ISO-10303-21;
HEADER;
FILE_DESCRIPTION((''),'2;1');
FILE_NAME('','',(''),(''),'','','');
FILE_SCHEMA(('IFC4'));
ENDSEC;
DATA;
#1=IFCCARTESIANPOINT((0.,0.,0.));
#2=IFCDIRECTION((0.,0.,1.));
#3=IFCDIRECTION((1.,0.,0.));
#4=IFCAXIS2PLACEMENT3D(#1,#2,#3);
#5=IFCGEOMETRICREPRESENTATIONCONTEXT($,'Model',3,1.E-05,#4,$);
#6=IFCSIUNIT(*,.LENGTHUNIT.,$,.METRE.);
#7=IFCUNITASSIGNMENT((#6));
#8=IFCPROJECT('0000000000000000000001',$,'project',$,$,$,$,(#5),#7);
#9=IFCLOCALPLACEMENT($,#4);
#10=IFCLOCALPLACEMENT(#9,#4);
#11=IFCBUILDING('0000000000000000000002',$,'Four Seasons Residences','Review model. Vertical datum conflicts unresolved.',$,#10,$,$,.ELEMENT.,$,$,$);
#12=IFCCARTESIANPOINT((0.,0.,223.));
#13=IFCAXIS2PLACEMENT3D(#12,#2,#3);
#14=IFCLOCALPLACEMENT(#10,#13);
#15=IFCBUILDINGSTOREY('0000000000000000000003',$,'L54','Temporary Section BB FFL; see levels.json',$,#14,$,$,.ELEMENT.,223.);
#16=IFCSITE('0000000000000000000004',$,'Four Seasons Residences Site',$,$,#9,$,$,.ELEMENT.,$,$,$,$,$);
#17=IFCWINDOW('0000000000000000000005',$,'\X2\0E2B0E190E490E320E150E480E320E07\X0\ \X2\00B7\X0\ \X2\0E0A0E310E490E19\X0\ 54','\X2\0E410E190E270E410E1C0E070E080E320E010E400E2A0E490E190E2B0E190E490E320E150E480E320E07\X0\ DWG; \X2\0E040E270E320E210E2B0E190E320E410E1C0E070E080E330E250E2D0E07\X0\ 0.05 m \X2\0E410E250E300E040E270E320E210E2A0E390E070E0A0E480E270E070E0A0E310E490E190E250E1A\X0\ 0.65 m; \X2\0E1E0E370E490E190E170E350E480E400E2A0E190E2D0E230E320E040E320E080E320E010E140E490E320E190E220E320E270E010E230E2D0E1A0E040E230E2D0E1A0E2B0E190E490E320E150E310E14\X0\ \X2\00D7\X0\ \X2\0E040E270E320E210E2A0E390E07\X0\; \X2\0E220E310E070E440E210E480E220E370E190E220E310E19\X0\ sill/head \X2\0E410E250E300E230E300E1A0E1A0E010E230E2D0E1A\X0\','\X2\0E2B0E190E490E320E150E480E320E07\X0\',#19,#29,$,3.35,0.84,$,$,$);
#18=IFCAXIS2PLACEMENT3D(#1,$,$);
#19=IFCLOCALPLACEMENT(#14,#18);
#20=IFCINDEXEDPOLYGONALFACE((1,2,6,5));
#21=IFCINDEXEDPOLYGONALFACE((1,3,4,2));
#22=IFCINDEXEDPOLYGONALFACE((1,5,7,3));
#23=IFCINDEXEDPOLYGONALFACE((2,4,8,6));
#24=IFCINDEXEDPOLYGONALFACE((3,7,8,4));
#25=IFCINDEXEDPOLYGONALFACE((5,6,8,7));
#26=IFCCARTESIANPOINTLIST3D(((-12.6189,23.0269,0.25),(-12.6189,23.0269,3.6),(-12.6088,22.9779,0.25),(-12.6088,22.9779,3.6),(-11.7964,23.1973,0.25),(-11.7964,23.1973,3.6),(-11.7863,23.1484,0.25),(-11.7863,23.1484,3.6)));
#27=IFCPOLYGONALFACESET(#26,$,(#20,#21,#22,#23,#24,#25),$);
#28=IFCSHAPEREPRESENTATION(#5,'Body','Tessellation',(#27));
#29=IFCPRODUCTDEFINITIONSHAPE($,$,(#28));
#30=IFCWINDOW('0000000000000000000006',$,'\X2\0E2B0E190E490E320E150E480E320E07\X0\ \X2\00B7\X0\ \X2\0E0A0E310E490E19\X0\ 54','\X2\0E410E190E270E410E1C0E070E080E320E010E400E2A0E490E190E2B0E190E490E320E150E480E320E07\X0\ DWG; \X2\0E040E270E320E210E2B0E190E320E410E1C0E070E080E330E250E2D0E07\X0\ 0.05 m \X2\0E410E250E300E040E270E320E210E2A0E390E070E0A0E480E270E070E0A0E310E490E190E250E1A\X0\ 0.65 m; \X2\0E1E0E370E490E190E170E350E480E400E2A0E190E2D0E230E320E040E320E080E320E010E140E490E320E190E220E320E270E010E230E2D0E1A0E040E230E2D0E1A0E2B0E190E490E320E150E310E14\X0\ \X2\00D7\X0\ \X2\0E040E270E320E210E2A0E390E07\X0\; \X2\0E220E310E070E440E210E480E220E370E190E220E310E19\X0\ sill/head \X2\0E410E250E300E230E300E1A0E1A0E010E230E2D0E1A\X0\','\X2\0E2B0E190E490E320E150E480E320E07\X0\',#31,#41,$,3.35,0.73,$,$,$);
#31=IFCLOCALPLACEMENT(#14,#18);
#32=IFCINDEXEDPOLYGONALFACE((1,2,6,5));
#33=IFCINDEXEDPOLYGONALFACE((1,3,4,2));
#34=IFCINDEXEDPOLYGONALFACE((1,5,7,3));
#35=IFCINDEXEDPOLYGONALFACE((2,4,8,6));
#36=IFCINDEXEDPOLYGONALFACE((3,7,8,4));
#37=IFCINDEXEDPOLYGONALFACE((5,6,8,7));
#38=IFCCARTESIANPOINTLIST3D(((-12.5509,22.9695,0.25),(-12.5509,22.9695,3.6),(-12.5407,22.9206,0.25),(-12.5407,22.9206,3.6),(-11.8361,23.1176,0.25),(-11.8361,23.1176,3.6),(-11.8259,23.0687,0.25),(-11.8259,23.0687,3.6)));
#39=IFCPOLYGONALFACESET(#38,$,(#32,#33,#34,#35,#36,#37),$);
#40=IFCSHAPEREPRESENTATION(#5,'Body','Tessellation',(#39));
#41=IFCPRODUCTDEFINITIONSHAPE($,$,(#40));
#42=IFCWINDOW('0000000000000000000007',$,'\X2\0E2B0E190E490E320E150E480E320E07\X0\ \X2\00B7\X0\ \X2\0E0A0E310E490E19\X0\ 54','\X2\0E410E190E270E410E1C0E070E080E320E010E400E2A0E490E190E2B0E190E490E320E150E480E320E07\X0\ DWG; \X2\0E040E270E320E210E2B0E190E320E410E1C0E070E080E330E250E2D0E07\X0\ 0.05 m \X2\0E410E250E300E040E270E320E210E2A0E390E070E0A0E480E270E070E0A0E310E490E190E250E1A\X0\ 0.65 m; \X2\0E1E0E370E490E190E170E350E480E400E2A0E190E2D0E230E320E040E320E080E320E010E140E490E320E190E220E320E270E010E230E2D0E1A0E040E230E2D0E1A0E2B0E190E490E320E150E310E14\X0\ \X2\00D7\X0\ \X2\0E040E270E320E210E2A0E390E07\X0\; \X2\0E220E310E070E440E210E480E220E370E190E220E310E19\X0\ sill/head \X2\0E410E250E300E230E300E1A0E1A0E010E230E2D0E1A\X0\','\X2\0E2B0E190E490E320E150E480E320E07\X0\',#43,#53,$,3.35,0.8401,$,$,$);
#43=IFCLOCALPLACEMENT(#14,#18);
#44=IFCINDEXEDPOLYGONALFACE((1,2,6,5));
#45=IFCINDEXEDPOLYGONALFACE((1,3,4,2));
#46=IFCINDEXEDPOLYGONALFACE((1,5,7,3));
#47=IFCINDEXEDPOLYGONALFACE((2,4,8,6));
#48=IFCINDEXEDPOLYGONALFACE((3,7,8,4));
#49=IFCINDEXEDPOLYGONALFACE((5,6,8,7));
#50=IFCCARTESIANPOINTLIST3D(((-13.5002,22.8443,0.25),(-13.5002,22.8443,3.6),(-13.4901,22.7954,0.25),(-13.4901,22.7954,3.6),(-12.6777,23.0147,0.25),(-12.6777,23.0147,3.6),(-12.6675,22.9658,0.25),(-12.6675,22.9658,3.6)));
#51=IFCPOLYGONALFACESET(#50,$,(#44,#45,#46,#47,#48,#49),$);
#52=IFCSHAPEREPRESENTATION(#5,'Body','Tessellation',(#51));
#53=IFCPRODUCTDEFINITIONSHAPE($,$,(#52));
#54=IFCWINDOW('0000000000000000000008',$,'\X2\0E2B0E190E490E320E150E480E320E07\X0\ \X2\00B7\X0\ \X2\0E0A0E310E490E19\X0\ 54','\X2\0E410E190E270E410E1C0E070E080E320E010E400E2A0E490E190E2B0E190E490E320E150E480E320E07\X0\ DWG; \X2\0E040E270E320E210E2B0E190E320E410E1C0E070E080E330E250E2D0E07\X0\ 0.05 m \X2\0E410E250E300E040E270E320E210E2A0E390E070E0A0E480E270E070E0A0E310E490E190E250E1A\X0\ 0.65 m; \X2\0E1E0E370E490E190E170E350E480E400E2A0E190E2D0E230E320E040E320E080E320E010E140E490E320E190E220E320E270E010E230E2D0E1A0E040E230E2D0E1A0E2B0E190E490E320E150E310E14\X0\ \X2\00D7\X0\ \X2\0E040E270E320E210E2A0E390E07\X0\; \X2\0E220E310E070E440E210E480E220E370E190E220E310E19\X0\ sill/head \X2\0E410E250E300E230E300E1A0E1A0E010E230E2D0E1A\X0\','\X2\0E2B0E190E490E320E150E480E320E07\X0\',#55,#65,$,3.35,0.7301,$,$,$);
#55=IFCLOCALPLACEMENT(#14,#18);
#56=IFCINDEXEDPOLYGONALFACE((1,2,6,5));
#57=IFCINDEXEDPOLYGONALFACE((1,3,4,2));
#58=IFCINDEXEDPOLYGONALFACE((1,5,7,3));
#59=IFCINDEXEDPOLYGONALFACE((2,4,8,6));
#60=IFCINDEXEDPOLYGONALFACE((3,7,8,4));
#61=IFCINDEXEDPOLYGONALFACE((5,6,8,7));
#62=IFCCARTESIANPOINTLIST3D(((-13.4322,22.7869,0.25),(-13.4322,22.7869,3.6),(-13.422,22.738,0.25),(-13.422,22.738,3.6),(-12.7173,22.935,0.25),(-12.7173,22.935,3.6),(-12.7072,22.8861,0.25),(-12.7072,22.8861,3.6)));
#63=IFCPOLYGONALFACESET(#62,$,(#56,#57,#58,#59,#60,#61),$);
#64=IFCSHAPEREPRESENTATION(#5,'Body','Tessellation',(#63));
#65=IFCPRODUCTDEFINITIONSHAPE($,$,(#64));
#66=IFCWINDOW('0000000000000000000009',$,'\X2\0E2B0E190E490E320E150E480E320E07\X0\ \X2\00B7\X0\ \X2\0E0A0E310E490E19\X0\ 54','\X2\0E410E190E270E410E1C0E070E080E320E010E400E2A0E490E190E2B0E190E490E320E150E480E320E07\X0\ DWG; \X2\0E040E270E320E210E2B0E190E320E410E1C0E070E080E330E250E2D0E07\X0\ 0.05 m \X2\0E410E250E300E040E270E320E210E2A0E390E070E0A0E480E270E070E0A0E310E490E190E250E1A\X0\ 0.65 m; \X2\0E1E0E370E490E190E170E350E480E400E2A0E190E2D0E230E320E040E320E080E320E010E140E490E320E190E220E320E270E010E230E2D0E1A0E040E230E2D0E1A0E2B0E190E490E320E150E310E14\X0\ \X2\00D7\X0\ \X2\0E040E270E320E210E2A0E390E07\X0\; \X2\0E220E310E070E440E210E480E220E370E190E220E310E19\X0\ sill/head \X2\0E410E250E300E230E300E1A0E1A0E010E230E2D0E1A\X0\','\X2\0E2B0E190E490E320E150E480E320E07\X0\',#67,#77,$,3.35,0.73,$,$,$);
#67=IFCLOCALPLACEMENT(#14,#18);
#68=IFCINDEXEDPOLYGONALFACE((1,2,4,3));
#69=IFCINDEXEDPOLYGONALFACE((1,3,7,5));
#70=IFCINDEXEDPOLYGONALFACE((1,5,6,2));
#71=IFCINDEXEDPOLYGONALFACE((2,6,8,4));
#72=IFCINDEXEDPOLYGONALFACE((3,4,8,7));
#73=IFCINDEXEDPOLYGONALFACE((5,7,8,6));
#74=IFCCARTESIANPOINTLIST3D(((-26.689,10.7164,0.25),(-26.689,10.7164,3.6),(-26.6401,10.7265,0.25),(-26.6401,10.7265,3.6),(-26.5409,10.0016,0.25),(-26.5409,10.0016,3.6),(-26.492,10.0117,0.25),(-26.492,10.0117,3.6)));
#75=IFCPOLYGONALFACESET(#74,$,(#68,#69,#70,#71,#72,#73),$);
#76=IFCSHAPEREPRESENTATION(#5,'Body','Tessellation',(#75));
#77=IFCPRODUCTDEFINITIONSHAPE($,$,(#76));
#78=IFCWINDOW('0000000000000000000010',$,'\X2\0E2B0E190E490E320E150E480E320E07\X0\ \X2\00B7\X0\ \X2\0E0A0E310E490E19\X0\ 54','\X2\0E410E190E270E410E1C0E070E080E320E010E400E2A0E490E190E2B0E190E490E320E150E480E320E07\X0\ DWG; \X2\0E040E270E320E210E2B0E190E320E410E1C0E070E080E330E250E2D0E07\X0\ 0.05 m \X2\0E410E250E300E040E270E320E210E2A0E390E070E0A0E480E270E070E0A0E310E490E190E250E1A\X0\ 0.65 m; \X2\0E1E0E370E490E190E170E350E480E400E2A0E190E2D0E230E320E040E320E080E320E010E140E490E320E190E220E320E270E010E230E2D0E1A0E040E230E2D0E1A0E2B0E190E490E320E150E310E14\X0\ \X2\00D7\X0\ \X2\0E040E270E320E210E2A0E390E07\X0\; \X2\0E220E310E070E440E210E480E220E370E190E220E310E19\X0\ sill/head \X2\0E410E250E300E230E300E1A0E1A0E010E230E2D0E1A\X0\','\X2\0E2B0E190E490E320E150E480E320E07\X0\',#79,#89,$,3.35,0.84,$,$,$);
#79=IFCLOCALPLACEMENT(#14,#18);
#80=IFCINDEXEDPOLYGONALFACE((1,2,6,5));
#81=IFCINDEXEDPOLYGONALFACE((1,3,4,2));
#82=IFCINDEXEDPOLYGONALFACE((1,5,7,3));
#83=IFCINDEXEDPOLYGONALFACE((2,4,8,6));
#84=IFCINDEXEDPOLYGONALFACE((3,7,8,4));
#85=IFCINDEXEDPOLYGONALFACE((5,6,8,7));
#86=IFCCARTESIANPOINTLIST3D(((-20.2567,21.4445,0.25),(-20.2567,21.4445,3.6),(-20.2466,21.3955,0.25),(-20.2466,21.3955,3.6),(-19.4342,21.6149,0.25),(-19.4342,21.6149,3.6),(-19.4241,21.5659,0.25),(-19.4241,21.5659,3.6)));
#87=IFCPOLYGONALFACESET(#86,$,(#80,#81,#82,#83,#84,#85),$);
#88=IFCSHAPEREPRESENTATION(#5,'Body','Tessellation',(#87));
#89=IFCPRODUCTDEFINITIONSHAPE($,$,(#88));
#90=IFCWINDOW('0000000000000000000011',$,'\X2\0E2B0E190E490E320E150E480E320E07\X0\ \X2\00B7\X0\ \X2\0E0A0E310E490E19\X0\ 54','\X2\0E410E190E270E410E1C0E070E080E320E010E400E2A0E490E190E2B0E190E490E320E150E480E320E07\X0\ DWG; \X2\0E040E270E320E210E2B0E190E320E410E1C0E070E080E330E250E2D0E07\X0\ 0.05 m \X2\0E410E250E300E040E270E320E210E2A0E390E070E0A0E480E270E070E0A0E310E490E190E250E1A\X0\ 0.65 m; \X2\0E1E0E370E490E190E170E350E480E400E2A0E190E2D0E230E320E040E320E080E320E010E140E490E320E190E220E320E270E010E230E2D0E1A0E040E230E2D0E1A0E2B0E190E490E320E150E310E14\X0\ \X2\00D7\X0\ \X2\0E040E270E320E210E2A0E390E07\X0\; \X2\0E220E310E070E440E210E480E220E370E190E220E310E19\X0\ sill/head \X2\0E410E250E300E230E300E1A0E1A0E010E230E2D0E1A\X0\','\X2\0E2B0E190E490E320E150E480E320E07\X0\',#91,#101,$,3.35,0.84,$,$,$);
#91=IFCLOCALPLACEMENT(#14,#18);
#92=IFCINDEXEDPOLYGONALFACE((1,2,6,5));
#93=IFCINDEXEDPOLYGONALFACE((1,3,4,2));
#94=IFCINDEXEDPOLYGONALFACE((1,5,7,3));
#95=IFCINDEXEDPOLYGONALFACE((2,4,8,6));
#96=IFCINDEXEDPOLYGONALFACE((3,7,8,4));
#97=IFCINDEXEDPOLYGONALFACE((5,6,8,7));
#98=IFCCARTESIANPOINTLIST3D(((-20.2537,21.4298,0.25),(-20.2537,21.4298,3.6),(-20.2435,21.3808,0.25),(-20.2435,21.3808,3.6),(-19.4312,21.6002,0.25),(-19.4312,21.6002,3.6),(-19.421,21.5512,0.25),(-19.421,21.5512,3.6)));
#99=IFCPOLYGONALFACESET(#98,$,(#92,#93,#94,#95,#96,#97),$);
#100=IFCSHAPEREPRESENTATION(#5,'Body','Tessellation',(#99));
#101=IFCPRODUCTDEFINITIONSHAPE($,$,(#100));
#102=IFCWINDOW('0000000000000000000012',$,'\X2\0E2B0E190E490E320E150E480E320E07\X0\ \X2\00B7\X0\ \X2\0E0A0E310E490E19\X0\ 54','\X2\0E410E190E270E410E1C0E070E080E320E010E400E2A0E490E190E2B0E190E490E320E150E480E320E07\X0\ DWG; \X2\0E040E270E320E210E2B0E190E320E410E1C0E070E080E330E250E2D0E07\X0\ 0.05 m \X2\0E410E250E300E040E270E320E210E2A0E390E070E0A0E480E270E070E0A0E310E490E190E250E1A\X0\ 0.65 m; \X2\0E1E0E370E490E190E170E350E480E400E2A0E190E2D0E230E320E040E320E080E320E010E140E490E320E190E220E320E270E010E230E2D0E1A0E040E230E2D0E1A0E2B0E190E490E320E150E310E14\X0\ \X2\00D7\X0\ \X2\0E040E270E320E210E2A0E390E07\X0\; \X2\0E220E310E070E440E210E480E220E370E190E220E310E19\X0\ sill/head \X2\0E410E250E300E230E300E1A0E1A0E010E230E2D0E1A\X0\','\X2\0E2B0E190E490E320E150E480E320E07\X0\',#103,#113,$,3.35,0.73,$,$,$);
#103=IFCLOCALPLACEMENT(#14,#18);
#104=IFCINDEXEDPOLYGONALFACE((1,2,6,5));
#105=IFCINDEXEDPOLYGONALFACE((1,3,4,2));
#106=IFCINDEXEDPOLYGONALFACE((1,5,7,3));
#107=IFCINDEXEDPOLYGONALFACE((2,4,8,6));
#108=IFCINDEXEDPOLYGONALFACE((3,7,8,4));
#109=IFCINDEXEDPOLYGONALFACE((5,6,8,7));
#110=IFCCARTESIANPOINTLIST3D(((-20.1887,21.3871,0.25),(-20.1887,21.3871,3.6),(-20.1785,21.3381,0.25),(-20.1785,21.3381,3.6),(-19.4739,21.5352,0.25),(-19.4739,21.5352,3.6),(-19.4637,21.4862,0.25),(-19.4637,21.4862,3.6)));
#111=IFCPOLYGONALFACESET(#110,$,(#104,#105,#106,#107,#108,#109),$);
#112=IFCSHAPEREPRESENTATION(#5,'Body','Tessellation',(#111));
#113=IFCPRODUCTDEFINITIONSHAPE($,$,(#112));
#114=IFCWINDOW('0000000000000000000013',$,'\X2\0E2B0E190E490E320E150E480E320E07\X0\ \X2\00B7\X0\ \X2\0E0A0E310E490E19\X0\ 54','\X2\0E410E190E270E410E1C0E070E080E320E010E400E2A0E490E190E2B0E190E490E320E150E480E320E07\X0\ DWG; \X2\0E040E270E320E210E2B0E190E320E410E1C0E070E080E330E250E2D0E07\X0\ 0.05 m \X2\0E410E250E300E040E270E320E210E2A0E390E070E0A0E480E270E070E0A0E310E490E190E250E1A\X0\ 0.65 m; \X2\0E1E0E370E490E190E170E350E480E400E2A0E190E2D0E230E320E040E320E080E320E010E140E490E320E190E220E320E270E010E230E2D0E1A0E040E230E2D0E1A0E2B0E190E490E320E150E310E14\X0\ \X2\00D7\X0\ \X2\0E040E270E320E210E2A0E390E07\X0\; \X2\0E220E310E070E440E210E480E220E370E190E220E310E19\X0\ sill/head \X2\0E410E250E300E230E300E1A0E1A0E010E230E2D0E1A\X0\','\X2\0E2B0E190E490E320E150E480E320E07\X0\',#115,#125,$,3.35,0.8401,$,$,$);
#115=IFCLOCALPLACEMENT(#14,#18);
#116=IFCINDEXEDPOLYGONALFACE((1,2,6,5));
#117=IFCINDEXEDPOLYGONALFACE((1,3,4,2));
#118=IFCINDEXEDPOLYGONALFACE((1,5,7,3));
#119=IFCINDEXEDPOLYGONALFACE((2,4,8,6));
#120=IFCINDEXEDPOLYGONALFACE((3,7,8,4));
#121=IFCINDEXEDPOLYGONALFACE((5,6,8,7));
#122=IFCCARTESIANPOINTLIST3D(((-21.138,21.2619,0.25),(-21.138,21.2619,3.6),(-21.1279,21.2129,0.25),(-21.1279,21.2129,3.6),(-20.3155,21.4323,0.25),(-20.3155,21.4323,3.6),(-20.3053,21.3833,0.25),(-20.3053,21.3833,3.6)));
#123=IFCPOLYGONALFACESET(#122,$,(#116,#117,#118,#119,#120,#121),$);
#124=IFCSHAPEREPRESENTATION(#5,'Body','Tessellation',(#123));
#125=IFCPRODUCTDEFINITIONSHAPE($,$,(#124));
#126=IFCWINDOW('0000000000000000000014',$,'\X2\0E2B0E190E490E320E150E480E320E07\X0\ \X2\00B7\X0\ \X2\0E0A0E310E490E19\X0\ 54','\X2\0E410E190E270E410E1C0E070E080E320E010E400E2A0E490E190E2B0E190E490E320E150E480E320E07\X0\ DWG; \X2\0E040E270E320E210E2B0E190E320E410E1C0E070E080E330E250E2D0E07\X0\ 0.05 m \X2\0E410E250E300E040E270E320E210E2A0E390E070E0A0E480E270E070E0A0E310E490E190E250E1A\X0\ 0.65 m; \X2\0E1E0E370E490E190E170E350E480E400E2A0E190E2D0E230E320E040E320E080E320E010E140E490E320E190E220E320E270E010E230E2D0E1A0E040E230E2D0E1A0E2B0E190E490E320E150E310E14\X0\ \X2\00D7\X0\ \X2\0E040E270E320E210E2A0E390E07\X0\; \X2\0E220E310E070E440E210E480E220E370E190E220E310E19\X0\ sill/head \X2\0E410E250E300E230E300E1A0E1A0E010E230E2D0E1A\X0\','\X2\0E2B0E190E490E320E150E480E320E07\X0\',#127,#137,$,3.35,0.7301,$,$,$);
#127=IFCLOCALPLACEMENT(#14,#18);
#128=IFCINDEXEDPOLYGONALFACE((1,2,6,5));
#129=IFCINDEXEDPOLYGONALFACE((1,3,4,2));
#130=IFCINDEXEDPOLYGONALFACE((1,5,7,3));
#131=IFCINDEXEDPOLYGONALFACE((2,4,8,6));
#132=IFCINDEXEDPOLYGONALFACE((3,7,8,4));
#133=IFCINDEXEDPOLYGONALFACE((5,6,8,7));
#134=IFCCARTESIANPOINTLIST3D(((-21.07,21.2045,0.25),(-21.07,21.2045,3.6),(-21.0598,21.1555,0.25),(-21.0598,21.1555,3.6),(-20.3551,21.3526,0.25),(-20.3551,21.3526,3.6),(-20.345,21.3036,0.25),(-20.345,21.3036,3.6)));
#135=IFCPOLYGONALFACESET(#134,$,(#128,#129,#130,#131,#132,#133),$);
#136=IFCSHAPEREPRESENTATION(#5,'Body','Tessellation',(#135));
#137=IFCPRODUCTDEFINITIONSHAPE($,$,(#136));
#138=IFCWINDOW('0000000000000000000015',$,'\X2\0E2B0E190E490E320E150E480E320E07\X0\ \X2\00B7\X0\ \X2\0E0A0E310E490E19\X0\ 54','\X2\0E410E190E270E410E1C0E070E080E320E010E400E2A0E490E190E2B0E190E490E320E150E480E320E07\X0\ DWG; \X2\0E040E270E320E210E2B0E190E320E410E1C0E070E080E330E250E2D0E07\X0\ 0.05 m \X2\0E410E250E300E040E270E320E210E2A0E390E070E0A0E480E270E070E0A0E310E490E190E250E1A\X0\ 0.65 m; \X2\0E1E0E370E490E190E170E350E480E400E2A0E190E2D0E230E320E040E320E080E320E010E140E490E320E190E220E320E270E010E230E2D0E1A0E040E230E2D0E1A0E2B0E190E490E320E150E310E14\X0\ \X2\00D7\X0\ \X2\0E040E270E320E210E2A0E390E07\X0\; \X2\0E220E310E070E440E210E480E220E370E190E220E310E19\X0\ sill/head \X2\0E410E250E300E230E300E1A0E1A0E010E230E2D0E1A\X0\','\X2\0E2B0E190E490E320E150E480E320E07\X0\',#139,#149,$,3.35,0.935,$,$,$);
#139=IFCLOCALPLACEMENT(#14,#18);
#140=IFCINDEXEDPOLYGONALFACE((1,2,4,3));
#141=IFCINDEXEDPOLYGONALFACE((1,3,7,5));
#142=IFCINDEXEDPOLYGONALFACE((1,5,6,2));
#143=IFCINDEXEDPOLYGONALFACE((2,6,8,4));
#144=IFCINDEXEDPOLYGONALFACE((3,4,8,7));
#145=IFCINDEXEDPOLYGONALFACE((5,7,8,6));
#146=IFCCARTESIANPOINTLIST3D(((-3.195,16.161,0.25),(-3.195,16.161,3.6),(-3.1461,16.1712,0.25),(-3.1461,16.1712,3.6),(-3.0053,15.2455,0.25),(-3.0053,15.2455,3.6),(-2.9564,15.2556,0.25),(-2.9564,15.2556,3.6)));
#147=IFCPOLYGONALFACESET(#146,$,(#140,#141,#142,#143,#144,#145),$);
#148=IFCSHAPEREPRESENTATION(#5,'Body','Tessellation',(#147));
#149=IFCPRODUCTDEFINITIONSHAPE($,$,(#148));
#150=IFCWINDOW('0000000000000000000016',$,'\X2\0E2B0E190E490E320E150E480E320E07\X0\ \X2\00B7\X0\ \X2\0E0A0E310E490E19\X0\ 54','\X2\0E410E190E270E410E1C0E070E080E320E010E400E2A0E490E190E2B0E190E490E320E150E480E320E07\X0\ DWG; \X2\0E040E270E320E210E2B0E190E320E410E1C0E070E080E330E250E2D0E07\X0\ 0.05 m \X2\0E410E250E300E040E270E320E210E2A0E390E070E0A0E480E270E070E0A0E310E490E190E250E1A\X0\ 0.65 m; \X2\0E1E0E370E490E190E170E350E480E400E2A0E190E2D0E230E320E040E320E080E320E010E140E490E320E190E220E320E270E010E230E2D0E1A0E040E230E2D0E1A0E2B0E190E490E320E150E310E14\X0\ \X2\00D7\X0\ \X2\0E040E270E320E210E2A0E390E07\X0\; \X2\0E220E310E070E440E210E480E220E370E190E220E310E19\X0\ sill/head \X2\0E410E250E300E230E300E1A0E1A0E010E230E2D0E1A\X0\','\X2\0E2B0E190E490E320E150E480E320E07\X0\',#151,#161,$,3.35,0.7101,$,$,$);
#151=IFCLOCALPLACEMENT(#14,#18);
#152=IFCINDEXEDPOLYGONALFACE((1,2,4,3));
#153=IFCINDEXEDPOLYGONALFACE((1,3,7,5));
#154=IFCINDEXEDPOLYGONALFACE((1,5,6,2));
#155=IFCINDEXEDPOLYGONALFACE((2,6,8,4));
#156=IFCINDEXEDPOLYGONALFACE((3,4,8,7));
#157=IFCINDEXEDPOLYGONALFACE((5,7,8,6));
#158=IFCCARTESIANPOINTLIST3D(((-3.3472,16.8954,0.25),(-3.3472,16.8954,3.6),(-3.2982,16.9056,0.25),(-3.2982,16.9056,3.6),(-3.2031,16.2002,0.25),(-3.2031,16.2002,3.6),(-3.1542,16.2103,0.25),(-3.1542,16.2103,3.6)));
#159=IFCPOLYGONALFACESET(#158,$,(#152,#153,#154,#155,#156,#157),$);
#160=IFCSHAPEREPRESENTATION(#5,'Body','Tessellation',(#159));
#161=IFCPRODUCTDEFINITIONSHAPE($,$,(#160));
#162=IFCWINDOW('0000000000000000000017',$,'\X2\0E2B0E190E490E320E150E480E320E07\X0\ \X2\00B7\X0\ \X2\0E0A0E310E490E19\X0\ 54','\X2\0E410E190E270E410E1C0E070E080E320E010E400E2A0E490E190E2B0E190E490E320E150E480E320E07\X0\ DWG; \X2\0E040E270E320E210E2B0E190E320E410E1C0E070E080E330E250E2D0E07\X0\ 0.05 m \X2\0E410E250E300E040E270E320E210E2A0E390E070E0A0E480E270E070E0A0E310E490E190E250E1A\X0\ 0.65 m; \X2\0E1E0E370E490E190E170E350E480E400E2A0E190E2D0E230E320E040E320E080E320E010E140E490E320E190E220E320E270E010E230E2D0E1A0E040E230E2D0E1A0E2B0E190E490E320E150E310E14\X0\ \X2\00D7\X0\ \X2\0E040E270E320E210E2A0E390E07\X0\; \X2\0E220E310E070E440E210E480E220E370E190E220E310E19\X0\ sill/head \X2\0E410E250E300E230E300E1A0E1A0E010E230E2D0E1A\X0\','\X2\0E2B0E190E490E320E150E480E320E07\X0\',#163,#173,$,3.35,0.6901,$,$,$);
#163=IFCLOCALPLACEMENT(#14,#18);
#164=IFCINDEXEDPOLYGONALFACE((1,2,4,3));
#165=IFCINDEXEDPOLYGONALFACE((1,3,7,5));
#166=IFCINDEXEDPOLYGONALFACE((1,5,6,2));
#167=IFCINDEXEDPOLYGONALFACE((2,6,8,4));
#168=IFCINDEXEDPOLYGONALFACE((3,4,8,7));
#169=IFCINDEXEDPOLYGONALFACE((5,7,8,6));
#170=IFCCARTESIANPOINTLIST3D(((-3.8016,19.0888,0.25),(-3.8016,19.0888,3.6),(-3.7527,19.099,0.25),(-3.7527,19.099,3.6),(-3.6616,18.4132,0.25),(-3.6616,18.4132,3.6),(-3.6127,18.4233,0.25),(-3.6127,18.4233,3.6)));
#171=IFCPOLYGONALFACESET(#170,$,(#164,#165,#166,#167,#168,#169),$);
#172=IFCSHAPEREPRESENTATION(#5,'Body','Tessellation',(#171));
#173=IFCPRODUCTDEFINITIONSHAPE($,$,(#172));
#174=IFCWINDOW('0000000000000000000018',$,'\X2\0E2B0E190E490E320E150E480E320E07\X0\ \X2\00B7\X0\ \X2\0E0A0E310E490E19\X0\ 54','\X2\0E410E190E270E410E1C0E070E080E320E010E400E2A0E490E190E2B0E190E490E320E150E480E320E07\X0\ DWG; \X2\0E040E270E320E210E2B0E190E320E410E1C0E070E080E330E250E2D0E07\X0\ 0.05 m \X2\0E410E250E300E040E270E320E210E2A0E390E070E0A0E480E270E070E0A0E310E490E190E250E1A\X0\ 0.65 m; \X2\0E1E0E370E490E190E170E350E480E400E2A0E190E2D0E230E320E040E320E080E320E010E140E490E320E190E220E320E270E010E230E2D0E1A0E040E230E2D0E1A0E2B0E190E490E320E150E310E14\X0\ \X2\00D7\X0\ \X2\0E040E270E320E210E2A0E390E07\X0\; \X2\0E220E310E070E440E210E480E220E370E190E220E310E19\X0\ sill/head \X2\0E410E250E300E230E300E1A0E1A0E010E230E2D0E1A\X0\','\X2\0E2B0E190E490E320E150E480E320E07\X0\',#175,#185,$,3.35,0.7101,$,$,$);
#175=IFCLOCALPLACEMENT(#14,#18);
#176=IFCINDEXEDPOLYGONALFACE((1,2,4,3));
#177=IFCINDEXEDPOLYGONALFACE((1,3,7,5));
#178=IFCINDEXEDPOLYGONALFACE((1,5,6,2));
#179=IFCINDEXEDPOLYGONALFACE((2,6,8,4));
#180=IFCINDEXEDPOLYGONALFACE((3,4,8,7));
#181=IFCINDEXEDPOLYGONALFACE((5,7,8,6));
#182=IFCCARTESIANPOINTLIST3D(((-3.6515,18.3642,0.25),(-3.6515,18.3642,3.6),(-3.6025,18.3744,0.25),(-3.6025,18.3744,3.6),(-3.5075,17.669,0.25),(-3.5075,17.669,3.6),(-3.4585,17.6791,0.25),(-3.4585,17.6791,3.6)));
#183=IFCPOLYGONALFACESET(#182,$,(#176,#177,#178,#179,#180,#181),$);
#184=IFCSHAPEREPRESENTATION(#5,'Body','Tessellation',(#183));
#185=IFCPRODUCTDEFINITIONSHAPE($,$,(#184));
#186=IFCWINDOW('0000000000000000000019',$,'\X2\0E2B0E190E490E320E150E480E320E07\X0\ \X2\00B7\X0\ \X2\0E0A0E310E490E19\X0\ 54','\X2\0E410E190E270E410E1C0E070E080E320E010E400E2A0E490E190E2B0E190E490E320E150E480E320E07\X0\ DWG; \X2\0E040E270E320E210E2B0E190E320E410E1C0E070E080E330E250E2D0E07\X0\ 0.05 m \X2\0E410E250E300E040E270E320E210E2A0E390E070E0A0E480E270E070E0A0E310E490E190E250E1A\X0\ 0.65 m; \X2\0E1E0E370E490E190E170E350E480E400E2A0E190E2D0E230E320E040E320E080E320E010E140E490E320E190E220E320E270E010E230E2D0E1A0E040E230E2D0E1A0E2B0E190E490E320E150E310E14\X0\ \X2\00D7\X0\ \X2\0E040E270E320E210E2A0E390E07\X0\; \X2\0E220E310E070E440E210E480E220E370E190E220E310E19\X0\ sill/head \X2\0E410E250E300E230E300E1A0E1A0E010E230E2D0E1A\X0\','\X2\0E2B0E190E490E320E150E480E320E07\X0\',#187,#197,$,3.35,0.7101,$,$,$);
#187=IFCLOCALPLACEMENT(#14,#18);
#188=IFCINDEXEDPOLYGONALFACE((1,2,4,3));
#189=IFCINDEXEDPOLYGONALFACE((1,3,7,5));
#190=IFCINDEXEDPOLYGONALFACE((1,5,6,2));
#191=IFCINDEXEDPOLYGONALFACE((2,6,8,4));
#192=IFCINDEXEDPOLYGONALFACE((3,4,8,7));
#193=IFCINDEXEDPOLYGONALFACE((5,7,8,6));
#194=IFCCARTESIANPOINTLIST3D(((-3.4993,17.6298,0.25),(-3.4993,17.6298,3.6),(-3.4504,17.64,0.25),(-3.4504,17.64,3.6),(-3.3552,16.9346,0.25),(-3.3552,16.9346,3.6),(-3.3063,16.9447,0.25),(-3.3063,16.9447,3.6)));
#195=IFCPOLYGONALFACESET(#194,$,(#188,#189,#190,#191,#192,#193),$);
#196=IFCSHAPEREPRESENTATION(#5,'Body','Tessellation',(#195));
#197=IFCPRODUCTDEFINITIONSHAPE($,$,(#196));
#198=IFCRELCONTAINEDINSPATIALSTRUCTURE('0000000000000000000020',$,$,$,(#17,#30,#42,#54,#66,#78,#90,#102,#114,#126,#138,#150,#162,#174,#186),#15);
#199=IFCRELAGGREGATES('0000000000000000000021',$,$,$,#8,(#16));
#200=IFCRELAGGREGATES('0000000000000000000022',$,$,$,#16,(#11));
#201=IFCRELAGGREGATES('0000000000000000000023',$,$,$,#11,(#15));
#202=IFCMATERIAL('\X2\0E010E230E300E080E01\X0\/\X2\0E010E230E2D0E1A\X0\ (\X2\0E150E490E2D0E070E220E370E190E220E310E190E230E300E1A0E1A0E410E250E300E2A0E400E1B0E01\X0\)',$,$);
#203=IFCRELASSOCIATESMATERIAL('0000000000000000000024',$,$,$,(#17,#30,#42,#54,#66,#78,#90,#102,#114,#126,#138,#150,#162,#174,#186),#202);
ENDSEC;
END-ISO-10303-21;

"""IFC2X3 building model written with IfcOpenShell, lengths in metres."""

from ifc_helpers import new_model, si_unit, frame, origin_with_axes, place, context, project, spatial, polyline, outline, extrude, material, element, save


model = new_model("IFC2X3")

# Units and contexts
model_context = context("Model", 3, precision=1e-05, world=origin_with_axes())
ifc_project = project(units=[si_unit("LENGTHUNIT", "METRE")], contexts=[model_context])

# Site, building, storey
site_placement = place(None, origin_with_axes())
site = spatial("IfcSite", under=ifc_project, at=site_placement, Name="Four Seasons Residences Site", CompositionType="ELEMENT")
building_placement = place(site_placement, origin_with_axes())
building = spatial("IfcBuilding", under=site, at=building_placement, Name="Four Seasons Residences", Description="Review model. Vertical datum conflicts unresolved.", CompositionType="ELEMENT")
storey_placement = place(building_placement, frame((0.0, 0.0, 223.0), z_axis=(0.0, 0.0, 1.0), x_axis=(1.0, 0.0, 0.0)))
storey = spatial("IfcBuildingStorey", under=building, at=storey_placement, Name="L54", Description="Temporary Section BB FFL; see levels.json", CompositionType="ELEMENT", Elevation=223.0)

# Windows
ifc_material = material(Name="กระจก/กรอบ (ต้องยืนยันระบบและสเปก)")
window_1_placement = place(storey_placement, origin_with_axes())
element("IfcWindow", 1, at=window_1_placement, inside=storey, material=ifc_material, Name="หน้าต่าง · ชั้น 54", Description="แนวแผงจากเส้นหน้าต่าง DWG; ความหนาแผงจำลอง 0.05 m และความสูงช่วงชั้นลบ 0.65 m; พื้นที่เสนอราคาจากด้านยาวกรอบครอบหน้าตัด × ความสูง; ยังไม่ยืนยัน sill/head และระบบกรอบ", ObjectType="หน้าต่าง", OverallHeight=3.35, OverallWidth=0.84, context=model_context, shape_type="SweptSolid", body=[
    extrude(outline(polyline([(-12.6088, 22.9779), (-12.6189, 23.0269), (-11.7964, 23.1973), (-11.7863, 23.1484), (-12.6088, 22.9779)])), frame((0.0, 0.0, 0.25), z_axis=(0.0, 0.0, 1.0), x_axis=(1.0, 0.0, 0.0)), (0.0, 0.0, 1.0), 3.35),
])
window_2_placement = place(storey_placement, origin_with_axes())
element("IfcWindow", 2, at=window_2_placement, inside=storey, material=ifc_material, Name="หน้าต่าง · ชั้น 54", Description="แนวแผงจากเส้นหน้าต่าง DWG; ความหนาแผงจำลอง 0.05 m และความสูงช่วงชั้นลบ 0.65 m; พื้นที่เสนอราคาจากด้านยาวกรอบครอบหน้าตัด × ความสูง; ยังไม่ยืนยัน sill/head และระบบกรอบ", ObjectType="หน้าต่าง", OverallHeight=3.35, OverallWidth=0.73, context=model_context, shape_type="SweptSolid", body=[
    extrude(outline(polyline([(-12.5407, 22.9206), (-12.5509, 22.9695), (-11.8361, 23.1176), (-11.8259, 23.0687), (-12.5407, 22.9206)])), frame((0.0, 0.0, 0.25), z_axis=(0.0, 0.0, 1.0), x_axis=(1.0, 0.0, 0.0)), (0.0, 0.0, 1.0), 3.35),
])
window_3_placement = place(storey_placement, origin_with_axes())
element("IfcWindow", 3, at=window_3_placement, inside=storey, material=ifc_material, Name="หน้าต่าง · ชั้น 54", Description="แนวแผงจากเส้นหน้าต่าง DWG; ความหนาแผงจำลอง 0.05 m และความสูงช่วงชั้นลบ 0.65 m; พื้นที่เสนอราคาจากด้านยาวกรอบครอบหน้าตัด × ความสูง; ยังไม่ยืนยัน sill/head และระบบกรอบ", ObjectType="หน้าต่าง", OverallHeight=3.35, OverallWidth=0.8401, context=model_context, shape_type="SweptSolid", body=[
    extrude(outline(polyline([(-13.4901, 22.7954), (-13.5002, 22.8443), (-12.6777, 23.0147), (-12.6675, 22.9658), (-13.4901, 22.7954)])), frame((0.0, 0.0, 0.25), z_axis=(0.0, 0.0, 1.0), x_axis=(1.0, 0.0, 0.0)), (0.0, 0.0, 1.0), 3.35),
])
window_4_placement = place(storey_placement, origin_with_axes())
element("IfcWindow", 4, at=window_4_placement, inside=storey, material=ifc_material, Name="หน้าต่าง · ชั้น 54", Description="แนวแผงจากเส้นหน้าต่าง DWG; ความหนาแผงจำลอง 0.05 m และความสูงช่วงชั้นลบ 0.65 m; พื้นที่เสนอราคาจากด้านยาวกรอบครอบหน้าตัด × ความสูง; ยังไม่ยืนยัน sill/head และระบบกรอบ", ObjectType="หน้าต่าง", OverallHeight=3.35, OverallWidth=0.7301, context=model_context, shape_type="SweptSolid", body=[
    extrude(outline(polyline([(-13.422, 22.738), (-13.4322, 22.7869), (-12.7173, 22.935), (-12.7072, 22.8861), (-13.422, 22.738)])), frame((0.0, 0.0, 0.25), z_axis=(0.0, 0.0, 1.0), x_axis=(1.0, 0.0, 0.0)), (0.0, 0.0, 1.0), 3.35),
])
window_5_placement = place(storey_placement, origin_with_axes())
element("IfcWindow", 5, at=window_5_placement, inside=storey, material=ifc_material, Name="หน้าต่าง · ชั้น 54", Description="แนวแผงจากเส้นหน้าต่าง DWG; ความหนาแผงจำลอง 0.05 m และความสูงช่วงชั้นลบ 0.65 m; พื้นที่เสนอราคาจากด้านยาวกรอบครอบหน้าตัด × ความสูง; ยังไม่ยืนยัน sill/head และระบบกรอบ", ObjectType="หน้าต่าง", OverallHeight=3.35, OverallWidth=0.73, context=model_context, shape_type="SweptSolid", body=[
    extrude(outline(polyline([(-26.689, 10.7164), (-26.6401, 10.7265), (-26.492, 10.0117), (-26.5409, 10.0016), (-26.689, 10.7164)])), frame((0.0, 0.0, 0.25), z_axis=(0.0, 0.0, 1.0), x_axis=(1.0, 0.0, 0.0)), (0.0, 0.0, 1.0), 3.35),
])
window_6_placement = place(storey_placement, origin_with_axes())
element("IfcWindow", 6, at=window_6_placement, inside=storey, material=ifc_material, Name="หน้าต่าง · ชั้น 54", Description="แนวแผงจากเส้นหน้าต่าง DWG; ความหนาแผงจำลอง 0.05 m และความสูงช่วงชั้นลบ 0.65 m; พื้นที่เสนอราคาจากด้านยาวกรอบครอบหน้าตัด × ความสูง; ยังไม่ยืนยัน sill/head และระบบกรอบ", ObjectType="หน้าต่าง", OverallHeight=3.35, OverallWidth=0.84, context=model_context, shape_type="SweptSolid", body=[
    extrude(outline(polyline([(-20.2466, 21.3955), (-20.2567, 21.4445), (-19.4342, 21.6149), (-19.4241, 21.5659), (-20.2466, 21.3955)])), frame((0.0, 0.0, 0.25), z_axis=(0.0, 0.0, 1.0), x_axis=(1.0, 0.0, 0.0)), (0.0, 0.0, 1.0), 3.35),
])
window_7_placement = place(storey_placement, origin_with_axes())
element("IfcWindow", 7, at=window_7_placement, inside=storey, material=ifc_material, Name="หน้าต่าง · ชั้น 54", Description="แนวแผงจากเส้นหน้าต่าง DWG; ความหนาแผงจำลอง 0.05 m และความสูงช่วงชั้นลบ 0.65 m; พื้นที่เสนอราคาจากด้านยาวกรอบครอบหน้าตัด × ความสูง; ยังไม่ยืนยัน sill/head และระบบกรอบ", ObjectType="หน้าต่าง", OverallHeight=3.35, OverallWidth=0.84, context=model_context, shape_type="SweptSolid", body=[
    extrude(outline(polyline([(-20.2435, 21.3808), (-20.2537, 21.4298), (-19.4312, 21.6002), (-19.421, 21.5512), (-20.2435, 21.3808)])), frame((0.0, 0.0, 0.25), z_axis=(0.0, 0.0, 1.0), x_axis=(1.0, 0.0, 0.0)), (0.0, 0.0, 1.0), 3.35),
])
window_8_placement = place(storey_placement, origin_with_axes())
element("IfcWindow", 8, at=window_8_placement, inside=storey, material=ifc_material, Name="หน้าต่าง · ชั้น 54", Description="แนวแผงจากเส้นหน้าต่าง DWG; ความหนาแผงจำลอง 0.05 m และความสูงช่วงชั้นลบ 0.65 m; พื้นที่เสนอราคาจากด้านยาวกรอบครอบหน้าตัด × ความสูง; ยังไม่ยืนยัน sill/head และระบบกรอบ", ObjectType="หน้าต่าง", OverallHeight=3.35, OverallWidth=0.73, context=model_context, shape_type="SweptSolid", body=[
    extrude(outline(polyline([(-20.1785, 21.3381), (-20.1887, 21.3871), (-19.4739, 21.5352), (-19.4637, 21.4862), (-20.1785, 21.3381)])), frame((0.0, 0.0, 0.25), z_axis=(0.0, 0.0, 1.0), x_axis=(1.0, 0.0, 0.0)), (0.0, 0.0, 1.0), 3.35),
])
window_9_placement = place(storey_placement, origin_with_axes())
element("IfcWindow", 9, at=window_9_placement, inside=storey, material=ifc_material, Name="หน้าต่าง · ชั้น 54", Description="แนวแผงจากเส้นหน้าต่าง DWG; ความหนาแผงจำลอง 0.05 m และความสูงช่วงชั้นลบ 0.65 m; พื้นที่เสนอราคาจากด้านยาวกรอบครอบหน้าตัด × ความสูง; ยังไม่ยืนยัน sill/head และระบบกรอบ", ObjectType="หน้าต่าง", OverallHeight=3.35, OverallWidth=0.8401, context=model_context, shape_type="SweptSolid", body=[
    extrude(outline(polyline([(-21.1279, 21.2129), (-21.138, 21.2619), (-20.3155, 21.4323), (-20.3053, 21.3833), (-21.1279, 21.2129)])), frame((0.0, 0.0, 0.25), z_axis=(0.0, 0.0, 1.0), x_axis=(1.0, 0.0, 0.0)), (0.0, 0.0, 1.0), 3.35),
])
window_10_placement = place(storey_placement, origin_with_axes())
element("IfcWindow", 10, at=window_10_placement, inside=storey, material=ifc_material, Name="หน้าต่าง · ชั้น 54", Description="แนวแผงจากเส้นหน้าต่าง DWG; ความหนาแผงจำลอง 0.05 m และความสูงช่วงชั้นลบ 0.65 m; พื้นที่เสนอราคาจากด้านยาวกรอบครอบหน้าตัด × ความสูง; ยังไม่ยืนยัน sill/head และระบบกรอบ", ObjectType="หน้าต่าง", OverallHeight=3.35, OverallWidth=0.7301, context=model_context, shape_type="SweptSolid", body=[
    extrude(outline(polyline([(-21.0598, 21.1555), (-21.07, 21.2045), (-20.3551, 21.3526), (-20.345, 21.3036), (-21.0598, 21.1555)])), frame((0.0, 0.0, 0.25), z_axis=(0.0, 0.0, 1.0), x_axis=(1.0, 0.0, 0.0)), (0.0, 0.0, 1.0), 3.35),
])
window_11_placement = place(storey_placement, origin_with_axes())
element("IfcWindow", 11, at=window_11_placement, inside=storey, material=ifc_material, Name="หน้าต่าง · ชั้น 54", Description="แนวแผงจากเส้นหน้าต่าง DWG; ความหนาแผงจำลอง 0.05 m และความสูงช่วงชั้นลบ 0.65 m; พื้นที่เสนอราคาจากด้านยาวกรอบครอบหน้าตัด × ความสูง; ยังไม่ยืนยัน sill/head และระบบกรอบ", ObjectType="หน้าต่าง", OverallHeight=3.35, OverallWidth=0.935, context=model_context, shape_type="SweptSolid", body=[
    extrude(outline(polyline([(-3.195, 16.161), (-3.1461, 16.1712), (-2.9564, 15.2556), (-3.0053, 15.2455), (-3.195, 16.161)])), frame((0.0, 0.0, 0.25), z_axis=(0.0, 0.0, 1.0), x_axis=(1.0, 0.0, 0.0)), (0.0, 0.0, 1.0), 3.35),
])
window_12_placement = place(storey_placement, origin_with_axes())
element("IfcWindow", 12, at=window_12_placement, inside=storey, material=ifc_material, Name="หน้าต่าง · ชั้น 54", Description="แนวแผงจากเส้นหน้าต่าง DWG; ความหนาแผงจำลอง 0.05 m และความสูงช่วงชั้นลบ 0.65 m; พื้นที่เสนอราคาจากด้านยาวกรอบครอบหน้าตัด × ความสูง; ยังไม่ยืนยัน sill/head และระบบกรอบ", ObjectType="หน้าต่าง", OverallHeight=3.35, OverallWidth=0.7101, context=model_context, shape_type="SweptSolid", body=[
    extrude(outline(polyline([(-3.3472, 16.8954), (-3.2982, 16.9056), (-3.1542, 16.2103), (-3.2031, 16.2002), (-3.3472, 16.8954)])), frame((0.0, 0.0, 0.25), z_axis=(0.0, 0.0, 1.0), x_axis=(1.0, 0.0, 0.0)), (0.0, 0.0, 1.0), 3.35),
])
window_13_placement = place(storey_placement, origin_with_axes())
element("IfcWindow", 13, at=window_13_placement, inside=storey, material=ifc_material, Name="หน้าต่าง · ชั้น 54", Description="แนวแผงจากเส้นหน้าต่าง DWG; ความหนาแผงจำลอง 0.05 m และความสูงช่วงชั้นลบ 0.65 m; พื้นที่เสนอราคาจากด้านยาวกรอบครอบหน้าตัด × ความสูง; ยังไม่ยืนยัน sill/head และระบบกรอบ", ObjectType="หน้าต่าง", OverallHeight=3.35, OverallWidth=0.6901, context=model_context, shape_type="SweptSolid", body=[
    extrude(outline(polyline([(-3.6127, 18.4233), (-3.6616, 18.4132), (-3.8016, 19.0888), (-3.7527, 19.099), (-3.6127, 18.4233)])), frame((0.0, 0.0, 0.25), z_axis=(0.0, 0.0, 1.0), x_axis=(1.0, 0.0, 0.0)), (0.0, 0.0, 1.0), 3.35),
])
window_14_placement = place(storey_placement, origin_with_axes())
element("IfcWindow", 14, at=window_14_placement, inside=storey, material=ifc_material, Name="หน้าต่าง · ชั้น 54", Description="แนวแผงจากเส้นหน้าต่าง DWG; ความหนาแผงจำลอง 0.05 m และความสูงช่วงชั้นลบ 0.65 m; พื้นที่เสนอราคาจากด้านยาวกรอบครอบหน้าตัด × ความสูง; ยังไม่ยืนยัน sill/head และระบบกรอบ", ObjectType="หน้าต่าง", OverallHeight=3.35, OverallWidth=0.7101, context=model_context, shape_type="SweptSolid", body=[
    extrude(outline(polyline([(-3.4585, 17.6791), (-3.5075, 17.669), (-3.6515, 18.3642), (-3.6025, 18.3744), (-3.4585, 17.6791)])), frame((0.0, 0.0, 0.25), z_axis=(0.0, 0.0, 1.0), x_axis=(1.0, 0.0, 0.0)), (0.0, 0.0, 1.0), 3.35),
])
window_15_placement = place(storey_placement, origin_with_axes())
element("IfcWindow", 15, at=window_15_placement, inside=storey, material=ifc_material, Name="หน้าต่าง · ชั้น 54", Description="แนวแผงจากเส้นหน้าต่าง DWG; ความหนาแผงจำลอง 0.05 m และความสูงช่วงชั้นลบ 0.65 m; พื้นที่เสนอราคาจากด้านยาวกรอบครอบหน้าตัด × ความสูง; ยังไม่ยืนยัน sill/head และระบบกรอบ", ObjectType="หน้าต่าง", OverallHeight=3.35, OverallWidth=0.7101, context=model_context, shape_type="SweptSolid", body=[
    extrude(outline(polyline([(-3.3063, 16.9447), (-3.3552, 16.9346), (-3.4993, 17.6298), (-3.4504, 17.64), (-3.3063, 16.9447)])), frame((0.0, 0.0, 0.25), z_axis=(0.0, 0.0, 1.0), x_axis=(1.0, 0.0, 0.0)), (0.0, 0.0, 1.0), 3.35),
])

save(model, "model.ifc")
